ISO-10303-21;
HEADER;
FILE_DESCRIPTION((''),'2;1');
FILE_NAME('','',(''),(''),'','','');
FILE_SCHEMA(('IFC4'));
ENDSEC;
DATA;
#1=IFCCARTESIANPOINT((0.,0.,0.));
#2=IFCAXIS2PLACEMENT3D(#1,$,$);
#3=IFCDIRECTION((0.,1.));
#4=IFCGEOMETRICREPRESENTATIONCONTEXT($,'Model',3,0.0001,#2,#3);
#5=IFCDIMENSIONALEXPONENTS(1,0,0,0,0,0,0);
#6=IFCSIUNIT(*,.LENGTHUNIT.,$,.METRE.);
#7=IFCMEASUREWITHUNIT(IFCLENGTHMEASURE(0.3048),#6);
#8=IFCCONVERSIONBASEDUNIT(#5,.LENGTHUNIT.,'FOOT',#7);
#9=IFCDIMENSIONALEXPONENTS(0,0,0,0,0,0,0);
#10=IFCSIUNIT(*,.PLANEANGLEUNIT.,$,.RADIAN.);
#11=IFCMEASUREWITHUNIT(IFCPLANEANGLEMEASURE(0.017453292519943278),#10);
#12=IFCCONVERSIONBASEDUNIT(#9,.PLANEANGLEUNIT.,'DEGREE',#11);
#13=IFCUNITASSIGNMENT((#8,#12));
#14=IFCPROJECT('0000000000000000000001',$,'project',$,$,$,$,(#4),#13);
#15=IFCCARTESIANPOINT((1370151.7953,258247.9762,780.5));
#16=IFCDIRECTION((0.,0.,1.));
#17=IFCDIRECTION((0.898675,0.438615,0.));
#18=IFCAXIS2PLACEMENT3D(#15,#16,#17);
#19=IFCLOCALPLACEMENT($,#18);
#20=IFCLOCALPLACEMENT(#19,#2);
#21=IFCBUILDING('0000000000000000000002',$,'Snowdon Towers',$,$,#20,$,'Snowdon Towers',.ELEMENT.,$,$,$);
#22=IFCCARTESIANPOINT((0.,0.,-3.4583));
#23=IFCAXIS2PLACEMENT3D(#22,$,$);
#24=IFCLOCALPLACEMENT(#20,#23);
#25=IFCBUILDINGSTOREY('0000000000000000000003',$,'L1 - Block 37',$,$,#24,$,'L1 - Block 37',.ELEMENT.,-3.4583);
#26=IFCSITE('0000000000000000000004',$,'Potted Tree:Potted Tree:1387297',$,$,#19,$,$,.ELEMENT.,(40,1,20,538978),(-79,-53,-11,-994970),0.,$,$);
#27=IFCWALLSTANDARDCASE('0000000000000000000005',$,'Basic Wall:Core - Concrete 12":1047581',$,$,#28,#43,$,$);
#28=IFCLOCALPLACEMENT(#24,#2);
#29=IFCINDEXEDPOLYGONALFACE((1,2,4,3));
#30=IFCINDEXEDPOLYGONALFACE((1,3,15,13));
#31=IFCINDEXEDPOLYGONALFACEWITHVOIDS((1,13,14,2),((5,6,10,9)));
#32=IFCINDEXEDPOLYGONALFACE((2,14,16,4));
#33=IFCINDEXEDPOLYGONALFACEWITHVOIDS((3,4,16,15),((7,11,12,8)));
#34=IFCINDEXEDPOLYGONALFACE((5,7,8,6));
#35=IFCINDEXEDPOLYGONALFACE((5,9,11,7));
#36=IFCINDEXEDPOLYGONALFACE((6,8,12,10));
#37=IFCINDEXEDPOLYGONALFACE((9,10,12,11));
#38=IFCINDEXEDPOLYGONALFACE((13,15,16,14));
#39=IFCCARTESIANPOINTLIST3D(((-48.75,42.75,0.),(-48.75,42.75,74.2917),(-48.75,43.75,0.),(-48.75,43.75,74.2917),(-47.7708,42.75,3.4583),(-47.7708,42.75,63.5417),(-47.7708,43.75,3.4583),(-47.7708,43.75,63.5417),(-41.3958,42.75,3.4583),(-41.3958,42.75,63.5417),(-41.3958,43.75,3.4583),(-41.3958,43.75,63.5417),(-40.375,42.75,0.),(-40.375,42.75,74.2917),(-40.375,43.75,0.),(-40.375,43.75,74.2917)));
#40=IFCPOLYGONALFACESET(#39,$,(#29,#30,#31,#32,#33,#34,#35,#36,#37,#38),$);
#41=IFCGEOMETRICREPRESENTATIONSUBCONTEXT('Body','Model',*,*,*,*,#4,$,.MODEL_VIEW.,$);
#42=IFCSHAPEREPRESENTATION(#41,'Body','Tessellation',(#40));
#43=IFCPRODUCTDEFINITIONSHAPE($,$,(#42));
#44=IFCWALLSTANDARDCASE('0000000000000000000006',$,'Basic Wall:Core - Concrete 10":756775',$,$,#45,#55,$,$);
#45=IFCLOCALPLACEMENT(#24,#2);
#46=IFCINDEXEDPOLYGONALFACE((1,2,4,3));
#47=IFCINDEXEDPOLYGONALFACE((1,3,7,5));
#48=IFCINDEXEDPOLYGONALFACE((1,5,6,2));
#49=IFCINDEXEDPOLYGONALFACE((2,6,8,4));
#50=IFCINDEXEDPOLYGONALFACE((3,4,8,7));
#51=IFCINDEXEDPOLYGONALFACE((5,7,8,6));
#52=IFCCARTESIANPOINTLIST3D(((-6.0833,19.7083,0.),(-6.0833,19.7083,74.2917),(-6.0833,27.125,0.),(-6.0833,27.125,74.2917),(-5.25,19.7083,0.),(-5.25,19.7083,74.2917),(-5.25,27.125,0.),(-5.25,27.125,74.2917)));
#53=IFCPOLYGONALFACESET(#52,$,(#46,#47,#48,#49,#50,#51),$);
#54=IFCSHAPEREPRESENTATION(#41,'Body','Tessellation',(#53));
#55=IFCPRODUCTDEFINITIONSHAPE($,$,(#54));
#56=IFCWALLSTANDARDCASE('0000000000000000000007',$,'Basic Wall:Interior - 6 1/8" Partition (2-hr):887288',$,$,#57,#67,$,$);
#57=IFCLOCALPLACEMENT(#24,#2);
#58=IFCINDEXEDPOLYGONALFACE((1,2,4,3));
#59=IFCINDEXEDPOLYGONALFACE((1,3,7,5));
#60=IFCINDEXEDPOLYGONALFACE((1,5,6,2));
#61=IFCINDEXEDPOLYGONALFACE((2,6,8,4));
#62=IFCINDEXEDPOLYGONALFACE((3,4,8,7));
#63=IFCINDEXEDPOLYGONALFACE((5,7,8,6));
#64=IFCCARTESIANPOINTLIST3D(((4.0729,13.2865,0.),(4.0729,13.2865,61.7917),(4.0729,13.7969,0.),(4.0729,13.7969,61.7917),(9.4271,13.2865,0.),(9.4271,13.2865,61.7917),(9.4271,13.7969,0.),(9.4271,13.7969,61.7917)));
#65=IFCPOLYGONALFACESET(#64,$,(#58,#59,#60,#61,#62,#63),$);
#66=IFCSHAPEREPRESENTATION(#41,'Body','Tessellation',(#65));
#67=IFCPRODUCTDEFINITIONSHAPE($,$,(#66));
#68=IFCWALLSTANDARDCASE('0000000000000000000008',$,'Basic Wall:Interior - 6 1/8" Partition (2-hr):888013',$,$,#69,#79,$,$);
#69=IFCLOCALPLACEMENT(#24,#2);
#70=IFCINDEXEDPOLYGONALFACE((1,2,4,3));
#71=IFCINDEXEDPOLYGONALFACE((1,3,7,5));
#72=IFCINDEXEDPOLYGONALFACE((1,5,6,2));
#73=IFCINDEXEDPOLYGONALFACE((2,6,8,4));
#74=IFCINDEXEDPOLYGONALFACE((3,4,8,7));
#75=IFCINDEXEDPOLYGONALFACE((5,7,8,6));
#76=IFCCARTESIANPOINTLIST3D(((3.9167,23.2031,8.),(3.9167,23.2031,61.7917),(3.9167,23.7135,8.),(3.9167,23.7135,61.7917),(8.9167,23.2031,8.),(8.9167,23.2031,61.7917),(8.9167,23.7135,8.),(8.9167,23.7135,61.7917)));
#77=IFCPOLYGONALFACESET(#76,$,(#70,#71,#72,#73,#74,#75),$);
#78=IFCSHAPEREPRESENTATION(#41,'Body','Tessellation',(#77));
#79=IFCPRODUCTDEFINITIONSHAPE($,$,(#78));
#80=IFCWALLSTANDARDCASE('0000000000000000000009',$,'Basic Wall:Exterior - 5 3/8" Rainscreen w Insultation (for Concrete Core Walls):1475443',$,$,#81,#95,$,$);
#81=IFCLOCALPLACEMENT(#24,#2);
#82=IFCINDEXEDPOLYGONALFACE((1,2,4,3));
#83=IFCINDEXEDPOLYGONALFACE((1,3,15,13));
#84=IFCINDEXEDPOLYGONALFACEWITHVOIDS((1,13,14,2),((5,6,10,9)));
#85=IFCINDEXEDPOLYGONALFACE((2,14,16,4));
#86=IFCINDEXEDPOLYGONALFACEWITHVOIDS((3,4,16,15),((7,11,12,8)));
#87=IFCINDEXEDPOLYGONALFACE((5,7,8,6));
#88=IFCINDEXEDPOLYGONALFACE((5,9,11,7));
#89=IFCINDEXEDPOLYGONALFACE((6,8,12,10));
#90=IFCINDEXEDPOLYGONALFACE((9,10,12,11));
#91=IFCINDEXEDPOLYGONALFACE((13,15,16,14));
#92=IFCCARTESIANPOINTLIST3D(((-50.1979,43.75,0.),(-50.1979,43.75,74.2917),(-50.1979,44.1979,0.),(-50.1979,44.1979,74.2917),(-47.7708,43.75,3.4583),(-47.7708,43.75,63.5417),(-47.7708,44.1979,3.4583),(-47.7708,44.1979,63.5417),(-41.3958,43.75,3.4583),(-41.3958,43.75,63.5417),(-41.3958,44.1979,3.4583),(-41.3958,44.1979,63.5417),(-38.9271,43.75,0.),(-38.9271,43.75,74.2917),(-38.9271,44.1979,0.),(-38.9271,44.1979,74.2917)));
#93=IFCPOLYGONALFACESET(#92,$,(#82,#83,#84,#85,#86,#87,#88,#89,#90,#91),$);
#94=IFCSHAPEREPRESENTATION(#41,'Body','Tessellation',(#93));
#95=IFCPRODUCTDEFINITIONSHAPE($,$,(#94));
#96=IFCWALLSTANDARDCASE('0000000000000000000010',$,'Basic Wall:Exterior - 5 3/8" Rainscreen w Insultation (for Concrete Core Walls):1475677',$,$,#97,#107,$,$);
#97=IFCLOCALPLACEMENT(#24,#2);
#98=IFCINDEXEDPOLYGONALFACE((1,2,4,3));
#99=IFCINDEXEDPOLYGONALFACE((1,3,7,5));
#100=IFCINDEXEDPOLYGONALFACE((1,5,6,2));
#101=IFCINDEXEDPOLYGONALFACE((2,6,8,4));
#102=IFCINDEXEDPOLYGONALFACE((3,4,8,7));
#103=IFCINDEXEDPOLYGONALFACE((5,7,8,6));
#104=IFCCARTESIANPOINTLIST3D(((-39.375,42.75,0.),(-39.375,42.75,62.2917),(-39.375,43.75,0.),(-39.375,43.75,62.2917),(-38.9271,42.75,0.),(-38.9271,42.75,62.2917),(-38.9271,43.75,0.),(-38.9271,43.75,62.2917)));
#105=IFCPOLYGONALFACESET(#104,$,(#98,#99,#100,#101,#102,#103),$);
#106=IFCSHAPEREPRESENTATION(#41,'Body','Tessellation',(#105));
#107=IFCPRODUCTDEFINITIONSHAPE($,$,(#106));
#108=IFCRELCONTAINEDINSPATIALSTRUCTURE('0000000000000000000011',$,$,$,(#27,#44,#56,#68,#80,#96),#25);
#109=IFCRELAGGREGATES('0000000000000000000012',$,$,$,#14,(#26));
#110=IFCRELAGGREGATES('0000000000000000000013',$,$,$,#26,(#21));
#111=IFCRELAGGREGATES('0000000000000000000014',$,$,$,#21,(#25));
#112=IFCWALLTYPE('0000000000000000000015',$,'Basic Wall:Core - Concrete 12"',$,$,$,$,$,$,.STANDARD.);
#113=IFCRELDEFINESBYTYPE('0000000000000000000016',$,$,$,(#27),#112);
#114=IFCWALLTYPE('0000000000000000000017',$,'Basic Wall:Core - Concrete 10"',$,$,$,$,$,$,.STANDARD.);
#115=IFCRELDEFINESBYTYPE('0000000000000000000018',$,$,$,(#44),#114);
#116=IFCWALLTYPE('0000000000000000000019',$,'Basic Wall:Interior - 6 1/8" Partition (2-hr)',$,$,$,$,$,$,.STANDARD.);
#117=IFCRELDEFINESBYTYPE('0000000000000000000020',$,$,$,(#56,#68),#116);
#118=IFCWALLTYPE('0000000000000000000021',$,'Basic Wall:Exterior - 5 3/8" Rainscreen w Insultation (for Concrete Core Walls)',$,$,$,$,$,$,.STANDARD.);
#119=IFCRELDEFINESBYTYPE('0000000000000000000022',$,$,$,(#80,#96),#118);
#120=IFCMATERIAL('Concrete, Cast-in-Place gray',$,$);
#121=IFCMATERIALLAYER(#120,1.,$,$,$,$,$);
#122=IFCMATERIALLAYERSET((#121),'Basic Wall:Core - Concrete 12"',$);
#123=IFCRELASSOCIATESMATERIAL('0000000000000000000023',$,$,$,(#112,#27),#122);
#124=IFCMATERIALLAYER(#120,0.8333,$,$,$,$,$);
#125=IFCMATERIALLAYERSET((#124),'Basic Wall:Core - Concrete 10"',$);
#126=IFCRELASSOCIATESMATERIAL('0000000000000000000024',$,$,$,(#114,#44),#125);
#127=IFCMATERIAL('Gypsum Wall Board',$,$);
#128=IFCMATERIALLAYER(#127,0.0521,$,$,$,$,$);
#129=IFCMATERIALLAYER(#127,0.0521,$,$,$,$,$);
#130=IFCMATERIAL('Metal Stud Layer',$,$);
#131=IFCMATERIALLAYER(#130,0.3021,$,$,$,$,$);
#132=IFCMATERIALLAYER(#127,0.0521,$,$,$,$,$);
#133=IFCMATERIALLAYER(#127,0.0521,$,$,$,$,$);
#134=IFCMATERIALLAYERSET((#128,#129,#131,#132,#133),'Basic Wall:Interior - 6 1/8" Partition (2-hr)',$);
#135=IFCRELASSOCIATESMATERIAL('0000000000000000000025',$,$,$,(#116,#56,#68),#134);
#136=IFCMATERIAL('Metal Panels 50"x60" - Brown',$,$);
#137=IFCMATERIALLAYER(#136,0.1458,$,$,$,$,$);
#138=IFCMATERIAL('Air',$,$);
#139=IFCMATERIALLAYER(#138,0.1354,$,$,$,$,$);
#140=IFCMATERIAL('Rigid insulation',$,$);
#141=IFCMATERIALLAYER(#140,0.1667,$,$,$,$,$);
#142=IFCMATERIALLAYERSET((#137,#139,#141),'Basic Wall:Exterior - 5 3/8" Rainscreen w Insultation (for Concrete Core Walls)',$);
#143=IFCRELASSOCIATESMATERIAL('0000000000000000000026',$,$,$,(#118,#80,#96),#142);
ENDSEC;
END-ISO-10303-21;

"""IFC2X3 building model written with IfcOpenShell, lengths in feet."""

from ifc_helpers import new_model, entity, si_unit, converted_unit, direction, frame, frame_2d, origin, origin_2d_with_axis, place, context, subcontext, project, spatial, rectangle, extrude, material, layer, layer_set, layer_usage, type_object, element, save


model = new_model("IFC2X3")

# Units and contexts
model_context = context("Model", 3, precision=0.0001, world=origin(), true_north=direction((0.0, 1.0)))
body_context = subcontext(model_context, "Body", "Model", "MODEL_VIEW")
ifc_project = project(units=[converted_unit("LENGTHUNIT", "FOOT", entity("IfcLengthMeasure", 0.3048), si_unit("LENGTHUNIT", "METRE"), dimensions=[1, 0, 0, 0, 0, 0, 0]), converted_unit("PLANEANGLEUNIT", "DEGREE", entity("IfcPlaneAngleMeasure", 0.017453292519943278), si_unit("PLANEANGLEUNIT", "RADIAN"), dimensions=[0, 0, 0, 0, 0, 0, 0])], contexts=[model_context])

# Site, building, storey
site_placement = place(None, frame((1370151.7953, 258247.9762, 780.5), z_axis=(0.0, 0.0, 1.0), x_axis=(0.898675, 0.438615, 0.0)))
site = spatial("IfcSite", under=ifc_project, at=site_placement, Name="Potted Tree:Potted Tree:1387297", CompositionType="ELEMENT", RefLatitude=(40, 1, 20, 538978), RefLongitude=(-79, -53, -11, -994970), RefElevation=0.0)
building_placement = place(site_placement, origin())
building = spatial("IfcBuilding", under=site, at=building_placement, Name="Snowdon Towers", LongName="Snowdon Towers", CompositionType="ELEMENT")
storey_placement = place(building_placement, frame((0.0, 0.0, -3.4583)))
storey = spatial("IfcBuildingStorey", under=building, at=storey_placement, Name="L1 - Block 37", LongName="L1 - Block 37", CompositionType="ELEMENT", Elevation=-3.4583)

# Wall, opening
ifc_material_1 = material(Name="Concrete, Cast-in-Place gray")
ifc_layer_1 = layer(ifc_material_1, 1.0)
ifc_layer_set_1 = layer_set([ifc_layer_1], Name="Basic Wall:Core - Concrete 12\"")
ifc_layer_usage_1 = layer_usage(ifc_layer_set_1, "AXIS2", "NEGATIVE", 0.5)
wall_type_1 = type_object("IfcWallType", Name="Basic Wall:Core - Concrete 12\"", PredefinedType="STANDARD", material=ifc_layer_set_1)
wall_1_placement = place(storey_placement, frame((-48.75, 43.25, 0.0)))
wall_1 = element("IfcWallStandardCase", 1, at=wall_1_placement, inside=storey, type_object=wall_type_1, material=ifc_layer_usage_1, Name="Basic Wall:Core - Concrete 12\":1047581", context=body_context, shape_type="SweptSolid", body=[
    extrude(rectangle(XDim=8.375, YDim=1.0, at=frame_2d((4.1875, 0.0), x_axis=(-1.0, 0.0))), origin(), (0.0, 0.0, 1.0), 74.2917),
])
opening_1_placement = place(wall_1_placement, origin())
element("IfcOpeningElement", 2, at=opening_1_placement, cuts=wall_1, ObjectType="Opening", context=body_context, shape_type="SweptSolid", body=[
    extrude(rectangle(XDim=60.0833, YDim=6.375, at=origin_2d_with_axis()), frame((4.1667, -1.0, 33.5), z_axis=(0.0, 1.0, 0.0), x_axis=(0.0, 0.0, 1.0)), (0.0, 0.0, 1.0), 2.0),
])

# Walls
ifc_layer_2 = layer(ifc_material_1, 0.8333)
ifc_layer_set_2 = layer_set([ifc_layer_2], Name="Basic Wall:Core - Concrete 10\"")
ifc_layer_usage_2 = layer_usage(ifc_layer_set_2, "AXIS2", "NEGATIVE", 0.4167)
wall_type_2 = type_object("IfcWallType", Name="Basic Wall:Core - Concrete 10\"", PredefinedType="STANDARD", material=ifc_layer_set_2)
wall_2_placement = place(storey_placement, frame((-5.6667, 19.7083, 0.0), z_axis=(0.0, 0.0, 1.0), x_axis=(0.0, 1.0, 0.0)))
element("IfcWallStandardCase", 3, at=wall_2_placement, inside=storey, type_object=wall_type_2, material=ifc_layer_usage_2, Name="Basic Wall:Core - Concrete 10\":756775", context=body_context, shape_type="SweptSolid", body=[
    extrude(rectangle(XDim=7.4167, YDim=0.8333, at=frame_2d((3.7083, 0.0), x_axis=(-1.0, 0.0))), origin(), (0.0, 0.0, 1.0), 74.2917),
])
ifc_material_2 = material(Name="Gypsum Wall Board")
ifc_layer_3 = layer(ifc_material_2, 0.0521)
ifc_layer_4 = layer(ifc_material_2, 0.0521)
ifc_material_3 = material(Name="Metal Stud Layer")
ifc_layer_5 = layer(ifc_material_3, 0.3021)
ifc_layer_6 = layer(ifc_material_2, 0.0521)
ifc_layer_7 = layer(ifc_material_2, 0.0521)
ifc_layer_set_3 = layer_set([ifc_layer_3, ifc_layer_4, ifc_layer_5, ifc_layer_6, ifc_layer_7], Name="Basic Wall:Interior - 6 1/8\" Partition (2-hr)")
ifc_layer_usage_3 = layer_usage(ifc_layer_set_3, "AXIS2", "NEGATIVE", 0.2552)
wall_type_3 = type_object("IfcWallType", Name="Basic Wall:Interior - 6 1/8\" Partition (2-hr)", PredefinedType="STANDARD", material=ifc_layer_set_3)
wall_3_placement = place(storey_placement, frame((4.0729, 13.5417, 0.0)))
element("IfcWallStandardCase", 4, at=wall_3_placement, inside=storey, type_object=wall_type_3, material=ifc_layer_usage_3, Name="Basic Wall:Interior - 6 1/8\" Partition (2-hr):887288", context=body_context, shape_type="SweptSolid", body=[
    extrude(rectangle(XDim=5.3542, YDim=0.5104, at=frame_2d((2.6771, 0.0), x_axis=(-1.0, 0.0))), origin(), (0.0, 0.0, 1.0), 61.7917),
])
ifc_layer_usage_4 = layer_usage(ifc_layer_set_3, "AXIS2", "NEGATIVE", 0.2552)
wall_4_placement = place(storey_placement, frame((3.9167, 23.4583, 8.0)))
element("IfcWallStandardCase", 5, at=wall_4_placement, inside=storey, type_object=wall_type_3, material=ifc_layer_usage_4, Name="Basic Wall:Interior - 6 1/8\" Partition (2-hr):888013", context=body_context, shape_type="SweptSolid", body=[
    extrude(rectangle(XDim=5.0, YDim=0.5104, at=frame_2d((2.5, 0.0), x_axis=(-1.0, 0.0))), origin(), (0.0, 0.0, 1.0), 53.7917),
])

# Wall, opening
ifc_material_4 = material(Name="Metal Panels 50\"x60\" - Brown")
ifc_layer_8 = layer(ifc_material_4, 0.1458)
ifc_material_5 = material(Name="Air")
ifc_layer_9 = layer(ifc_material_5, 0.1354)
ifc_material_6 = material(Name="Rigid insulation")
ifc_layer_10 = layer(ifc_material_6, 0.1667)
ifc_layer_set_4 = layer_set([ifc_layer_8, ifc_layer_9, ifc_layer_10], Name="Basic Wall:Exterior - 5 3/8\" Rainscreen w Insultation (for Concrete Core Walls)")
ifc_layer_usage_5 = layer_usage(ifc_layer_set_4, "AXIS2", "NEGATIVE", 0.224)
wall_type_4 = type_object("IfcWallType", Name="Basic Wall:Exterior - 5 3/8\" Rainscreen w Insultation (for Concrete Core Walls)", PredefinedType="STANDARD", material=ifc_layer_set_4)
wall_5_placement = place(storey_placement, frame((-50.1979, 43.974, 0.0)))
wall_5 = element("IfcWallStandardCase", 6, at=wall_5_placement, inside=storey, type_object=wall_type_4, material=ifc_layer_usage_5, Name="Basic Wall:Exterior - 5 3/8\" Rainscreen w Insultation (for Concrete Core Walls):1475443", context=body_context, shape_type="SweptSolid", body=[
    extrude(rectangle(XDim=11.2708, YDim=0.4479, at=frame_2d((5.6354, 0.0), x_axis=(-1.0, 0.0))), origin(), (0.0, 0.0, 1.0), 74.2917),
])
opening_2_placement = place(wall_5_placement, origin())
element("IfcOpeningElement", 7, at=opening_2_placement, cuts=wall_5, ObjectType="Opening", context=body_context, shape_type="SweptSolid", body=[
    extrude(rectangle(XDim=60.0833, YDim=6.375, at=origin_2d_with_axis()), frame((5.6146, -0.724, 33.5), z_axis=(0.0, 1.0, 0.0), x_axis=(0.0, 0.0, 1.0)), (0.0, 0.0, 1.0), 1.4479),
])

# Wall
ifc_layer_usage_6 = layer_usage(ifc_layer_set_4, "AXIS2", "POSITIVE", -0.224)
wall_6_placement = place(storey_placement, frame((-39.151, 42.75, 0.0), z_axis=(0.0, 0.0, 1.0), x_axis=(0.0, 1.0, 0.0)))
element("IfcWallStandardCase", 8, at=wall_6_placement, inside=storey, type_object=wall_type_4, material=ifc_layer_usage_6, Name="Basic Wall:Exterior - 5 3/8\" Rainscreen w Insultation (for Concrete Core Walls):1475677", context=body_context, shape_type="SweptSolid", body=[
    extrude(rectangle(XDim=1.0, YDim=0.4479, at=frame_2d((0.5, 0.0), x_axis=(-1.0, 0.0))), origin(), (0.0, 0.0, 1.0), 62.2917),
])

save(model, "model.ifc")
